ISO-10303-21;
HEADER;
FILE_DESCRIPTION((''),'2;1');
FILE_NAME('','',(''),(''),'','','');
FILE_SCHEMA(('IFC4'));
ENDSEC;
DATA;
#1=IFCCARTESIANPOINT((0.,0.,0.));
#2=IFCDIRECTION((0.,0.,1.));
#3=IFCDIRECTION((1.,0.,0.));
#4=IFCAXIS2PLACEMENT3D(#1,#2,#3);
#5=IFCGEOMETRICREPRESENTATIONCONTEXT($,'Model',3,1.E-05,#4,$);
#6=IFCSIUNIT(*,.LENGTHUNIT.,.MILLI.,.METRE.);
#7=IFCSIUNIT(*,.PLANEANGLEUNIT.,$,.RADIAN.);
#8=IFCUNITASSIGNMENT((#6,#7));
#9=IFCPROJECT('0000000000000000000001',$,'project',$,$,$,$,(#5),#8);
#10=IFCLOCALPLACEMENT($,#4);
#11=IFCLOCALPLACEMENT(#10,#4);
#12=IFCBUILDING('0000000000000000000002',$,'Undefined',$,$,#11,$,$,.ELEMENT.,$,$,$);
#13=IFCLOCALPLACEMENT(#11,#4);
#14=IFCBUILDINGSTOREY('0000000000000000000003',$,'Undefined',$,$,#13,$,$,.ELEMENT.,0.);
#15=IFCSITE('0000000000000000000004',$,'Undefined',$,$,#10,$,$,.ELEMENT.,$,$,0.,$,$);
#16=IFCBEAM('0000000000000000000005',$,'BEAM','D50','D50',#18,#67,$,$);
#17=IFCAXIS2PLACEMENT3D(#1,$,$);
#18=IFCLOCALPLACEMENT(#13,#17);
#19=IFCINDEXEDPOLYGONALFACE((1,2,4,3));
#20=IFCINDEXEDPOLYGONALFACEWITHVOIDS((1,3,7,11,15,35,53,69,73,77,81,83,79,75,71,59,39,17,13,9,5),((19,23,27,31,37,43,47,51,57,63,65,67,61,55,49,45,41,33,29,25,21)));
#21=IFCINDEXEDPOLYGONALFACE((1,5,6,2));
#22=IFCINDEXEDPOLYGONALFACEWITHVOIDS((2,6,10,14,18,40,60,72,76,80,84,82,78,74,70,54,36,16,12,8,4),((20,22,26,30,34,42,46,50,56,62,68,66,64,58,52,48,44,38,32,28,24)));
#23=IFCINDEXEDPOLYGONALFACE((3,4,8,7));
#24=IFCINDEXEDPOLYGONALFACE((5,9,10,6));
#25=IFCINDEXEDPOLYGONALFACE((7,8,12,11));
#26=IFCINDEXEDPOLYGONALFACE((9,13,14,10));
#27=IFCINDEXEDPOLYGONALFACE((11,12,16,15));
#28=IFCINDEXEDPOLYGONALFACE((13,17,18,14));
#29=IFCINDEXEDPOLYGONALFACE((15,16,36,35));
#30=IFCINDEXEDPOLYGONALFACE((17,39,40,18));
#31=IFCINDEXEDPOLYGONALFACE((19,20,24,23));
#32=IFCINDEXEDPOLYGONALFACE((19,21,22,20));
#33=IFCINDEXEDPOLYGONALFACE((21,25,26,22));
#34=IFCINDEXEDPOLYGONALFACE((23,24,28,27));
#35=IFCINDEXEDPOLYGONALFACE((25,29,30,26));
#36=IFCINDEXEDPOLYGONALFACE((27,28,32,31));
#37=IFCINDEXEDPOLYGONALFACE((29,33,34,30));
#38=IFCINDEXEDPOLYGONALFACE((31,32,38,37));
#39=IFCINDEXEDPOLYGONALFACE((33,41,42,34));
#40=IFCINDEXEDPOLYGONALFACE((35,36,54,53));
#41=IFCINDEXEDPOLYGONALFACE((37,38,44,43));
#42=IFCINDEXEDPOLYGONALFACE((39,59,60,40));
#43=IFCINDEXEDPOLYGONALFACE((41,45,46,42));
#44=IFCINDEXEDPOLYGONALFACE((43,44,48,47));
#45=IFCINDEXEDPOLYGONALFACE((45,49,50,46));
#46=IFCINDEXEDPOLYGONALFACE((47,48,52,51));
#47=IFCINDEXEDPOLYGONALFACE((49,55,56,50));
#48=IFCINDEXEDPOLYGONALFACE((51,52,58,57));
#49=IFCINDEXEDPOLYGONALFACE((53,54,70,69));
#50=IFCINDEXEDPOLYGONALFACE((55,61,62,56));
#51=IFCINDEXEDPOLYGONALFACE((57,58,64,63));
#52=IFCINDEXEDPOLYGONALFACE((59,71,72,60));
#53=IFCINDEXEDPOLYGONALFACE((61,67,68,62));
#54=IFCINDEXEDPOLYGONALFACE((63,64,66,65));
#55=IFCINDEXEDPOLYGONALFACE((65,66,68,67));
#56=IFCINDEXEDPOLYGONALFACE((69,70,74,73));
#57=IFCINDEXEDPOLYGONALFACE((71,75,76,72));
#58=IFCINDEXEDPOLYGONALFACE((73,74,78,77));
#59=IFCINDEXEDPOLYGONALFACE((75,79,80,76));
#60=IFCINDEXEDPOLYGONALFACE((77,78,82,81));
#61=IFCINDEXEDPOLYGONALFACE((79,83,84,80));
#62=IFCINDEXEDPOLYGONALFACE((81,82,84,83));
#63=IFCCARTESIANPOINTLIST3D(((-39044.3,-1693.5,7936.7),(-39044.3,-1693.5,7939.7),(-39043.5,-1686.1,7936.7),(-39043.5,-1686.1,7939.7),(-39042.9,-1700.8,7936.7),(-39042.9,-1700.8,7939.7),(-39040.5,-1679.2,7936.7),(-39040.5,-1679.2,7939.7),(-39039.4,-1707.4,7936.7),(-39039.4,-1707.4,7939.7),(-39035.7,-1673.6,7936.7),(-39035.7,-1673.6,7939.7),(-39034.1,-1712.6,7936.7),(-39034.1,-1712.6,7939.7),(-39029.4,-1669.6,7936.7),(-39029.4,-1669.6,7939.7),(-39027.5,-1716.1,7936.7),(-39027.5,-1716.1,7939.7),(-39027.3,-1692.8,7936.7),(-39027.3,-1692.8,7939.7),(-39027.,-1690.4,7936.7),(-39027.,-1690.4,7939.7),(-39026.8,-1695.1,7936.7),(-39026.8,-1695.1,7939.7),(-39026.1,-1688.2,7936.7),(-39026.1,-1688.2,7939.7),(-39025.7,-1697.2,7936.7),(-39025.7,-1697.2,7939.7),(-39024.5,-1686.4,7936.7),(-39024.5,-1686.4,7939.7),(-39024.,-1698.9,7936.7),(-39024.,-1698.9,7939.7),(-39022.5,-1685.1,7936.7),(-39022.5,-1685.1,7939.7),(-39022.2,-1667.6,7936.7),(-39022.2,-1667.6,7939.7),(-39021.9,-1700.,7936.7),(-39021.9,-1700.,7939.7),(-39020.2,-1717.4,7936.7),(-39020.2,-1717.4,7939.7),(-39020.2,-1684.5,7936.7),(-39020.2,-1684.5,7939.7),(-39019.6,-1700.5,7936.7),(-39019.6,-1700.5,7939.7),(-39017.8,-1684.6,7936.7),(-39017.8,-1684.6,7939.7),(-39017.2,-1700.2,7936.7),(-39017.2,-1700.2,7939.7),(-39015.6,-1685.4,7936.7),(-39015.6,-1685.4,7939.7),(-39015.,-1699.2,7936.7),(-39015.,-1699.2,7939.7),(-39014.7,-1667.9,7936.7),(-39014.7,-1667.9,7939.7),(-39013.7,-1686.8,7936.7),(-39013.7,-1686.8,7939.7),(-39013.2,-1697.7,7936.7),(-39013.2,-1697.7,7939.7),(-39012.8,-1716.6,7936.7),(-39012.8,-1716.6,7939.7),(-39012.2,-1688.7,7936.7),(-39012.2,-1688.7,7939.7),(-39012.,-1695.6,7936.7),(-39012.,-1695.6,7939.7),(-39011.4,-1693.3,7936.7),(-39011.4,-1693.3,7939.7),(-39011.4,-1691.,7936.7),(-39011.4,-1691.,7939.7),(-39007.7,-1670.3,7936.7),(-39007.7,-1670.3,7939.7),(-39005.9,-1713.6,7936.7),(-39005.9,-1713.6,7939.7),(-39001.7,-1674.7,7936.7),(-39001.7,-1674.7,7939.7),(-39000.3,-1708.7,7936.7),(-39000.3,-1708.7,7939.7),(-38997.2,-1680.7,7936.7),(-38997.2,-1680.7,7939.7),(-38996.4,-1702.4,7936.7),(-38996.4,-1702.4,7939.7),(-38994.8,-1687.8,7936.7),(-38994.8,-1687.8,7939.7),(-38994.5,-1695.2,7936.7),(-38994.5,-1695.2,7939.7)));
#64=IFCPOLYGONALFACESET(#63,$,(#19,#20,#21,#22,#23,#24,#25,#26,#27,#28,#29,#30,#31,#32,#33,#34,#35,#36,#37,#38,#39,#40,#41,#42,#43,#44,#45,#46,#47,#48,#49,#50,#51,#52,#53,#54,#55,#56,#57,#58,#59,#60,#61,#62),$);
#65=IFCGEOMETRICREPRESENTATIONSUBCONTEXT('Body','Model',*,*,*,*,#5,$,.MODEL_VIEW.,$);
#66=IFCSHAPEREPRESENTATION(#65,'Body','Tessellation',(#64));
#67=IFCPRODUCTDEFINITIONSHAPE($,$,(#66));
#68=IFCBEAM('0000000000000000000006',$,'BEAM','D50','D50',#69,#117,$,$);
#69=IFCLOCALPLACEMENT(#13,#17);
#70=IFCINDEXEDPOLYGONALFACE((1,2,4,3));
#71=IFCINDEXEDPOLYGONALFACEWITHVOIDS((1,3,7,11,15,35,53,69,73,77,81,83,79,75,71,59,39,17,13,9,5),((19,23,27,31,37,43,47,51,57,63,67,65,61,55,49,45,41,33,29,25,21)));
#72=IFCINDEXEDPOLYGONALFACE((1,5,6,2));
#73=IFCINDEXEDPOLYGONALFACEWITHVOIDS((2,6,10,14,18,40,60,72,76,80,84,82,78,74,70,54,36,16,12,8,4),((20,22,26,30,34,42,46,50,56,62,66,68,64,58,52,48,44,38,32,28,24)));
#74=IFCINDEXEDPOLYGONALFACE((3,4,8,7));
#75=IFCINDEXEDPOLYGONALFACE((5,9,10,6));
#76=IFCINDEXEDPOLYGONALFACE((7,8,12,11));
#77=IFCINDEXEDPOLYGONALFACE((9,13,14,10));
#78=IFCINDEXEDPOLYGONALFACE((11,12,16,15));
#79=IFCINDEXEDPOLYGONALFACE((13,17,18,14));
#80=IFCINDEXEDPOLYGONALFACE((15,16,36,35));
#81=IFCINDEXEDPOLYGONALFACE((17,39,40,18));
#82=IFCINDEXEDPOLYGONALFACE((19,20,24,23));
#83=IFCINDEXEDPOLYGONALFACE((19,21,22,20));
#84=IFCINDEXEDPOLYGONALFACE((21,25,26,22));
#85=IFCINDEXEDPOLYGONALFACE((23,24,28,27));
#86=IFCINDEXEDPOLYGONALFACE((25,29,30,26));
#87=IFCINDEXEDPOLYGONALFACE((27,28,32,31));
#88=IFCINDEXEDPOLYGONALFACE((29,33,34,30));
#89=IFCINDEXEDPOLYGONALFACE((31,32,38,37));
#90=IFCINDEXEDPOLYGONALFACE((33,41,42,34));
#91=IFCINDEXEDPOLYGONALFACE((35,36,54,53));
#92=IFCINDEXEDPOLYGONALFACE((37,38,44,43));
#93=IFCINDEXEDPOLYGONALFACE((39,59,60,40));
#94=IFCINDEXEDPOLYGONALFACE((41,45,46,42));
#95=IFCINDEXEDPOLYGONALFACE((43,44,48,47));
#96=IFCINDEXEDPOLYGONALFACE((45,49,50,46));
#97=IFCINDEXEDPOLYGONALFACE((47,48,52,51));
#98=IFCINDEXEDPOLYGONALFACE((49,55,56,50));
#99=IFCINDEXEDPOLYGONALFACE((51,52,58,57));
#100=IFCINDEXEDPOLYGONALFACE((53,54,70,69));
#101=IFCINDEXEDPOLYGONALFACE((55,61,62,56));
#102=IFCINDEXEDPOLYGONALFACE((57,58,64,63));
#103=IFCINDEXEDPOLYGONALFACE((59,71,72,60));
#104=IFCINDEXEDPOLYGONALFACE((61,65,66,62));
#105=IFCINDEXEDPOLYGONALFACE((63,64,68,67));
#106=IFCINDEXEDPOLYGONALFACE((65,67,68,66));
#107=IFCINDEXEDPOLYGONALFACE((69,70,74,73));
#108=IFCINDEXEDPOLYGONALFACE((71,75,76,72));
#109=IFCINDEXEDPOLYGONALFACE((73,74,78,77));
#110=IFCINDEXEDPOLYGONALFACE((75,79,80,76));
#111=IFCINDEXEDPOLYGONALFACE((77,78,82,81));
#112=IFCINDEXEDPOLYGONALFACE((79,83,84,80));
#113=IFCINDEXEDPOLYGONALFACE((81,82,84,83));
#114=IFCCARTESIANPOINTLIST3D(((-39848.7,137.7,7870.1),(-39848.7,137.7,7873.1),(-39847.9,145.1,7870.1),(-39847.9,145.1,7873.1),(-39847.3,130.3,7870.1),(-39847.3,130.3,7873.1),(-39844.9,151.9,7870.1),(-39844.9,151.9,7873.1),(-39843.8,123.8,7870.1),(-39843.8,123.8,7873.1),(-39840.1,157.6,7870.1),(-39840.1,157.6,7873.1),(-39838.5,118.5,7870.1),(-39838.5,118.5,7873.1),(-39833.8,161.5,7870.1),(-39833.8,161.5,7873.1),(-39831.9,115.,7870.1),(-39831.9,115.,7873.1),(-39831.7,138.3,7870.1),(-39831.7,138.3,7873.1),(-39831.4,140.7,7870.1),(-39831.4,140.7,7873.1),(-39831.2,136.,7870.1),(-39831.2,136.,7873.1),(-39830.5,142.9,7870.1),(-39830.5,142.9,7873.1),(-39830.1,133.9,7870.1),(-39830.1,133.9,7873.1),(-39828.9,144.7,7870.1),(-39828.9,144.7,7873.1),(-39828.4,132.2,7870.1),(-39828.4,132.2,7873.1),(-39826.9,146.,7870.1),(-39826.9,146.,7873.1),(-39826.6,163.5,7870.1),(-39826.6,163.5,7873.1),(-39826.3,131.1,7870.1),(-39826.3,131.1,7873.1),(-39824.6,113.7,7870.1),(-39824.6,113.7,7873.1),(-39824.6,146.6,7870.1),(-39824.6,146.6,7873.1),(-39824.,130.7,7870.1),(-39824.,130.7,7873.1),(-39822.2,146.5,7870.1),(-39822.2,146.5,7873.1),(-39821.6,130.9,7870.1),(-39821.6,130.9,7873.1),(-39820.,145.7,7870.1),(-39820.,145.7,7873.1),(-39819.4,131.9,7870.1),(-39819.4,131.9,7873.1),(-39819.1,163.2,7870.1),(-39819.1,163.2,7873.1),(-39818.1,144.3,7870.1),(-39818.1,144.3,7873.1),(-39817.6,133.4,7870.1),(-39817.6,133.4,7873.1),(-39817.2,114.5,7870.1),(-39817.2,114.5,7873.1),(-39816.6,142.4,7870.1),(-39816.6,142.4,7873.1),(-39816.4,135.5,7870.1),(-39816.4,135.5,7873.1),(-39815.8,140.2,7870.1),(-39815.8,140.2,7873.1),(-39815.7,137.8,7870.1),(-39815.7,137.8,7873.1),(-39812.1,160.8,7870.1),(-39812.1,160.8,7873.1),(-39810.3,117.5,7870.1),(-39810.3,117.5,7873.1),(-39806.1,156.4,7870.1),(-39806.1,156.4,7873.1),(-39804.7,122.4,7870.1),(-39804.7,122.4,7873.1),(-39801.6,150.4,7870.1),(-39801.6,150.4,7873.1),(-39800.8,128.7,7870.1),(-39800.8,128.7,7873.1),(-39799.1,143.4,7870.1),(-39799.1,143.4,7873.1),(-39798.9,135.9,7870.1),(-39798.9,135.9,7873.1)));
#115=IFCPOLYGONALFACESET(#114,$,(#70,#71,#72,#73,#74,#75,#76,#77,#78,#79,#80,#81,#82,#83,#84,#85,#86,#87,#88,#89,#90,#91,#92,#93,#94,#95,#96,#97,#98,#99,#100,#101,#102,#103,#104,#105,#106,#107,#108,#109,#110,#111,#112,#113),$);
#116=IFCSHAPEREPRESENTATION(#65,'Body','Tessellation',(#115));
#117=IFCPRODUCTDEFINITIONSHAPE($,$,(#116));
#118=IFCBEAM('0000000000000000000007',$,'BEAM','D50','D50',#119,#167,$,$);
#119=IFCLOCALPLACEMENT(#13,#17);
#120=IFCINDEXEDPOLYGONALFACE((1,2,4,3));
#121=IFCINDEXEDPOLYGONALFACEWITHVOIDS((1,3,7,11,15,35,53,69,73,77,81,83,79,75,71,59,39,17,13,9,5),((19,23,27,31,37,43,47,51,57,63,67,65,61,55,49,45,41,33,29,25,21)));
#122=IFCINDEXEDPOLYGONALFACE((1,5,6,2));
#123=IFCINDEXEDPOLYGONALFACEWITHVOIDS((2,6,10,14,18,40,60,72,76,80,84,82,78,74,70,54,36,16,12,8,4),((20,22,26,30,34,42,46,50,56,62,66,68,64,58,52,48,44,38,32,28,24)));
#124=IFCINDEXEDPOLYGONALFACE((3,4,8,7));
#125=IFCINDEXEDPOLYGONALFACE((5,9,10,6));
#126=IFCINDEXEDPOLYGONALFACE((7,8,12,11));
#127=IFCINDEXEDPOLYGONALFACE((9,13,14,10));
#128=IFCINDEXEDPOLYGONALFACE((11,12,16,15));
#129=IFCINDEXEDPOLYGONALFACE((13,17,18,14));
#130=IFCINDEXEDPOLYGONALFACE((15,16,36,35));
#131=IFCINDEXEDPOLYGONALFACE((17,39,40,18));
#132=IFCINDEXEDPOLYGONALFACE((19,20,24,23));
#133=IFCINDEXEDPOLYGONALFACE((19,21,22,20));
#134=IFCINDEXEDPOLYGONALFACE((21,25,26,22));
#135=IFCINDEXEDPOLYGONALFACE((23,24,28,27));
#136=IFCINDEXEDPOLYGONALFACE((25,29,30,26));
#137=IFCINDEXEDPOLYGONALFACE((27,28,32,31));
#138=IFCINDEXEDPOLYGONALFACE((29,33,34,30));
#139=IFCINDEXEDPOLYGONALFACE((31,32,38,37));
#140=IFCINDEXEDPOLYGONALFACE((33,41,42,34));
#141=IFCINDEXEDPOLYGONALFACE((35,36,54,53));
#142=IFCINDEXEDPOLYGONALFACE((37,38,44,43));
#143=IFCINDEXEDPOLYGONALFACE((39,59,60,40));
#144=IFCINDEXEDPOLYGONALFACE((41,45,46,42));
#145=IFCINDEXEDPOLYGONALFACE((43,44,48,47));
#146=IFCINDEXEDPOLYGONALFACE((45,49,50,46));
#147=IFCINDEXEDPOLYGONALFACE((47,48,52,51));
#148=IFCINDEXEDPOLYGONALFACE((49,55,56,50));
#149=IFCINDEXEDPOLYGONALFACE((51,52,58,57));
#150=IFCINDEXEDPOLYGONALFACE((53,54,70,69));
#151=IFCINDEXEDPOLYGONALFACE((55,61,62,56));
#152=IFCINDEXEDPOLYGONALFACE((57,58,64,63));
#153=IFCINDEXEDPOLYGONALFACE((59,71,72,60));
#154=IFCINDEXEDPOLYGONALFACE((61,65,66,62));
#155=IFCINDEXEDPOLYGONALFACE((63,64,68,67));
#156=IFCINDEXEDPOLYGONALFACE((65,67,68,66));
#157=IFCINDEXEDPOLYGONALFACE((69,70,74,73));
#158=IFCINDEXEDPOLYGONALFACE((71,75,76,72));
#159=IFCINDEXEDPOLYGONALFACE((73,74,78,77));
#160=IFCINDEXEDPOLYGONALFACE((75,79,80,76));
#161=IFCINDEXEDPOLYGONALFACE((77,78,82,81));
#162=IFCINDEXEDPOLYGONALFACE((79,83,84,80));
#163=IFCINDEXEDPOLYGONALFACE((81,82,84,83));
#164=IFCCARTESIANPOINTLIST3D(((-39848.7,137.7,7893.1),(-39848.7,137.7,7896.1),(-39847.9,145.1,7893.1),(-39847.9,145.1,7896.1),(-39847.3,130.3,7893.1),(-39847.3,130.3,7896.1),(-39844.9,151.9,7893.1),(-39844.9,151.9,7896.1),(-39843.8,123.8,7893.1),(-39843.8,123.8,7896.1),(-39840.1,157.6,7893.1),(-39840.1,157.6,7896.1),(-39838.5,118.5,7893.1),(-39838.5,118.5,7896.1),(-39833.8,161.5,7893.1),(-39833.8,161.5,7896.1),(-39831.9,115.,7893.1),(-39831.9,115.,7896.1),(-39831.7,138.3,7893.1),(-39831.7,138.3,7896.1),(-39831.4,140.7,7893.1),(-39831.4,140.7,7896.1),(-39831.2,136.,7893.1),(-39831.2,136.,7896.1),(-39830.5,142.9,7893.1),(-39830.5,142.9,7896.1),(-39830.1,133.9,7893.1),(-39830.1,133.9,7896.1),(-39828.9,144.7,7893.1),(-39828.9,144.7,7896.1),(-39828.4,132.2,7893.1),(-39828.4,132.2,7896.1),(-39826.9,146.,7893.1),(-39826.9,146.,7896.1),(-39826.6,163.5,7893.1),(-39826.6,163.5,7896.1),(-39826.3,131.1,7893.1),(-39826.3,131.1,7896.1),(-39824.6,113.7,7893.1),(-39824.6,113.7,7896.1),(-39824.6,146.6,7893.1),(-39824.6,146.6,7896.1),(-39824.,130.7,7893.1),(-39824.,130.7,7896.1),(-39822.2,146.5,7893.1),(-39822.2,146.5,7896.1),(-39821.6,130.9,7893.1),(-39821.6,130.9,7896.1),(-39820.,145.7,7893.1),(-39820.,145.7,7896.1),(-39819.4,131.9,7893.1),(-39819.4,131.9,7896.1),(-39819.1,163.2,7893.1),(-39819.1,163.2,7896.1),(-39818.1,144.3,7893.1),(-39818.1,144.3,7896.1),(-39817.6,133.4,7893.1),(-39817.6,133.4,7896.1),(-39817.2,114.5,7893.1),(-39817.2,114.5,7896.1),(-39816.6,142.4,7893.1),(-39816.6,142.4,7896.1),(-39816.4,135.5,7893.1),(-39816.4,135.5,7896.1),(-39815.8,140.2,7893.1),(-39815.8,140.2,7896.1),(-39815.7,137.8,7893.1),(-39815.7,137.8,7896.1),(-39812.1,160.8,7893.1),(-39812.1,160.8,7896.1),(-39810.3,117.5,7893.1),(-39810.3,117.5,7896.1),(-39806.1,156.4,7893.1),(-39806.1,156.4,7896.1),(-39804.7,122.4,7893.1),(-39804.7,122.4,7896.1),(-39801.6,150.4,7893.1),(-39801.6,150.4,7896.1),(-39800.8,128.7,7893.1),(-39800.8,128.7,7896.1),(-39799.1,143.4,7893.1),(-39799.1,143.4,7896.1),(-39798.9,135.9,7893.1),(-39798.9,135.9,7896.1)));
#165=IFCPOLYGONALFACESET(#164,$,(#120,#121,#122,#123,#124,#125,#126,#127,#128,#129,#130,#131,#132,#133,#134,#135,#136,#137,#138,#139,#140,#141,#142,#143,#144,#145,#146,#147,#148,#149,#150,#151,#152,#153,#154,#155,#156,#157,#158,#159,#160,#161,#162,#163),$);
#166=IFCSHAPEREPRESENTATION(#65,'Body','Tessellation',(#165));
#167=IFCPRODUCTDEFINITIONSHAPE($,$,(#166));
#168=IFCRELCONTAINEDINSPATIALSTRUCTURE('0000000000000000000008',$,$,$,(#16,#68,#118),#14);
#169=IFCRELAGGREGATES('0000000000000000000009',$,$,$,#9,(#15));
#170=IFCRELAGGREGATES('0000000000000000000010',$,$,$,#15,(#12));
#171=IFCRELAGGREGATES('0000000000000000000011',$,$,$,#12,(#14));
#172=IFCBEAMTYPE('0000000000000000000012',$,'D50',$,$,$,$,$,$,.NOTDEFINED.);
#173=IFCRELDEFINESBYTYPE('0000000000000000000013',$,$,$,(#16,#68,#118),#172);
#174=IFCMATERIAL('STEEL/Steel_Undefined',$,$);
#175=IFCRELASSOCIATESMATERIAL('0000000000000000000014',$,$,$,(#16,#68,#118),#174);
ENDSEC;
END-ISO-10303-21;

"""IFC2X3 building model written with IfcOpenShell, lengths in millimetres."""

from ifc_helpers import new_model, si_unit, frame, origin_with_axes, origin_2d_with_axis, place, context, subcontext, project, spatial, circle, extrude, material, type_object, element, save


model = new_model("IFC2X3")

# Units and contexts
model_context = context("Model", 3, precision=1e-05, world=origin_with_axes())
body_context = subcontext(model_context, "Body", "Model", "MODEL_VIEW")
ifc_project = project(units=[si_unit("LENGTHUNIT", "METRE", prefix="MILLI"), si_unit("PLANEANGLEUNIT", "RADIAN")], contexts=[model_context])

# Site, building, storey
site_placement = place(None, origin_with_axes())
site = spatial("IfcSite", under=ifc_project, at=site_placement, Name="Undefined", CompositionType="ELEMENT", RefElevation=0.0)
building_placement = place(site_placement, origin_with_axes())
building = spatial("IfcBuilding", under=site, at=building_placement, Name="Undefined", CompositionType="ELEMENT")
storey_placement = place(building_placement, origin_with_axes())
storey = spatial("IfcBuildingStorey", under=building, at=storey_placement, Name="Undefined", CompositionType="ELEMENT", Elevation=0.0)

# Shared definitions
ifc_material = material(Name="STEEL/Steel_Undefined")

# Beams, openings
beam_type_1 = type_object("IfcBeamType", Name="D50", PredefinedType="NOTDEFINED")
beam_1_placement = place(storey_placement, frame((-39019.3, -1692.5, 7939.7), z_axis=(-0.915553, -0.402198, 0.0), x_axis=(0.0, 0.0, -1.0)))
beam_1 = element("IfcBeam", 1, at=beam_1_placement, inside=storey, type_object=beam_type_1, material=ifc_material, Name="BEAM", Description="D50", ObjectType="D50", context=body_context, shape_type="SweptSolid", body=[
    extrude(circle(Radius=25.0, at=origin_2d_with_axis()), frame((3.0, 0.0, 0.0), z_axis=(-1.0, 0.0, 0.0), x_axis=(0.0, -1.0, 0.0)), (0.0, 0.0, 1.0), 3.0),
])
opening_1_placement = place(storey_placement, frame((-39019.3, -1692.5, 7939.7), z_axis=(-0.915553, -0.402198, 0.0), x_axis=(0.0, 0.0, -1.0)))
element("IfcOpeningElement", 2, at=opening_1_placement, cuts=beam_1, ObjectType="Recess", context=body_context, shape_type="SweptSolid", body=[
    extrude(circle(Radius=8.0, at=origin_2d_with_axis()), frame((268.5, 0.0, 0.0), z_axis=(-1.0, 0.0, 0.0), x_axis=(0.0, -1.0, 0.0)), (0.0, 0.0, 1.0), 292.6),
])
beam_2_placement = place(storey_placement, frame((-39823.7, 138.7, 7873.1), z_axis=(-0.915553, -0.402198, 0.0), x_axis=(0.0, 0.0, -1.0)))
beam_2 = element("IfcBeam", 3, at=beam_2_placement, inside=storey, type_object=beam_type_1, material=ifc_material, Name="BEAM", Description="D50", ObjectType="D50", context=body_context, shape_type="SweptSolid", body=[
    extrude(circle(Radius=25.0, at=origin_2d_with_axis()), frame((3.0, 0.0, 0.0), z_axis=(-1.0, 0.0, 0.0), x_axis=(0.0, -1.0, 0.0)), (0.0, 0.0, 1.0), 3.0),
])
opening_2_placement = place(storey_placement, frame((-39823.7, 138.7, 7873.1), z_axis=(-0.915553, -0.402198, 0.0), x_axis=(0.0, 0.0, -1.0)))
element("IfcOpeningElement", 4, at=opening_2_placement, cuts=beam_2, ObjectType="Recess", context=body_context, shape_type="SweptSolid", body=[
    extrude(circle(Radius=8.0, at=origin_2d_with_axis()), frame((245.5, 0.0, 0.0), z_axis=(-1.0, 0.0, 0.0), x_axis=(0.0, -1.0, 0.0)), (0.0, 0.0, 1.0), 292.6),
])
beam_3_placement = place(storey_placement, frame((-39823.7, 138.7, 7896.1), z_axis=(-0.915553, -0.402198, 0.0), x_axis=(0.0, 0.0, -1.0)))
beam_3 = element("IfcBeam", 5, at=beam_3_placement, inside=storey, type_object=beam_type_1, material=ifc_material, Name="BEAM", Description="D50", ObjectType="D50", context=body_context, shape_type="SweptSolid", body=[
    extrude(circle(Radius=25.0, at=origin_2d_with_axis()), frame((3.0, 0.0, 0.0), z_axis=(-1.0, 0.0, 0.0), x_axis=(0.0, -1.0, 0.0)), (0.0, 0.0, 1.0), 3.0),
])
opening_3_placement = place(storey_placement, frame((-39823.7, 138.7, 7896.1), z_axis=(-0.915553, -0.402198, 0.0), x_axis=(0.0, 0.0, -1.0)))
element("IfcOpeningElement", 6, at=opening_3_placement, cuts=beam_3, ObjectType="Recess", context=body_context, shape_type="SweptSolid", body=[
    extrude(circle(Radius=8.0, at=origin_2d_with_axis()), frame((268.5, 0.0, 0.0), z_axis=(-1.0, 0.0, 0.0), x_axis=(0.0, -1.0, 0.0)), (0.0, 0.0, 1.0), 292.6),
])

save(model, "model.ifc")
